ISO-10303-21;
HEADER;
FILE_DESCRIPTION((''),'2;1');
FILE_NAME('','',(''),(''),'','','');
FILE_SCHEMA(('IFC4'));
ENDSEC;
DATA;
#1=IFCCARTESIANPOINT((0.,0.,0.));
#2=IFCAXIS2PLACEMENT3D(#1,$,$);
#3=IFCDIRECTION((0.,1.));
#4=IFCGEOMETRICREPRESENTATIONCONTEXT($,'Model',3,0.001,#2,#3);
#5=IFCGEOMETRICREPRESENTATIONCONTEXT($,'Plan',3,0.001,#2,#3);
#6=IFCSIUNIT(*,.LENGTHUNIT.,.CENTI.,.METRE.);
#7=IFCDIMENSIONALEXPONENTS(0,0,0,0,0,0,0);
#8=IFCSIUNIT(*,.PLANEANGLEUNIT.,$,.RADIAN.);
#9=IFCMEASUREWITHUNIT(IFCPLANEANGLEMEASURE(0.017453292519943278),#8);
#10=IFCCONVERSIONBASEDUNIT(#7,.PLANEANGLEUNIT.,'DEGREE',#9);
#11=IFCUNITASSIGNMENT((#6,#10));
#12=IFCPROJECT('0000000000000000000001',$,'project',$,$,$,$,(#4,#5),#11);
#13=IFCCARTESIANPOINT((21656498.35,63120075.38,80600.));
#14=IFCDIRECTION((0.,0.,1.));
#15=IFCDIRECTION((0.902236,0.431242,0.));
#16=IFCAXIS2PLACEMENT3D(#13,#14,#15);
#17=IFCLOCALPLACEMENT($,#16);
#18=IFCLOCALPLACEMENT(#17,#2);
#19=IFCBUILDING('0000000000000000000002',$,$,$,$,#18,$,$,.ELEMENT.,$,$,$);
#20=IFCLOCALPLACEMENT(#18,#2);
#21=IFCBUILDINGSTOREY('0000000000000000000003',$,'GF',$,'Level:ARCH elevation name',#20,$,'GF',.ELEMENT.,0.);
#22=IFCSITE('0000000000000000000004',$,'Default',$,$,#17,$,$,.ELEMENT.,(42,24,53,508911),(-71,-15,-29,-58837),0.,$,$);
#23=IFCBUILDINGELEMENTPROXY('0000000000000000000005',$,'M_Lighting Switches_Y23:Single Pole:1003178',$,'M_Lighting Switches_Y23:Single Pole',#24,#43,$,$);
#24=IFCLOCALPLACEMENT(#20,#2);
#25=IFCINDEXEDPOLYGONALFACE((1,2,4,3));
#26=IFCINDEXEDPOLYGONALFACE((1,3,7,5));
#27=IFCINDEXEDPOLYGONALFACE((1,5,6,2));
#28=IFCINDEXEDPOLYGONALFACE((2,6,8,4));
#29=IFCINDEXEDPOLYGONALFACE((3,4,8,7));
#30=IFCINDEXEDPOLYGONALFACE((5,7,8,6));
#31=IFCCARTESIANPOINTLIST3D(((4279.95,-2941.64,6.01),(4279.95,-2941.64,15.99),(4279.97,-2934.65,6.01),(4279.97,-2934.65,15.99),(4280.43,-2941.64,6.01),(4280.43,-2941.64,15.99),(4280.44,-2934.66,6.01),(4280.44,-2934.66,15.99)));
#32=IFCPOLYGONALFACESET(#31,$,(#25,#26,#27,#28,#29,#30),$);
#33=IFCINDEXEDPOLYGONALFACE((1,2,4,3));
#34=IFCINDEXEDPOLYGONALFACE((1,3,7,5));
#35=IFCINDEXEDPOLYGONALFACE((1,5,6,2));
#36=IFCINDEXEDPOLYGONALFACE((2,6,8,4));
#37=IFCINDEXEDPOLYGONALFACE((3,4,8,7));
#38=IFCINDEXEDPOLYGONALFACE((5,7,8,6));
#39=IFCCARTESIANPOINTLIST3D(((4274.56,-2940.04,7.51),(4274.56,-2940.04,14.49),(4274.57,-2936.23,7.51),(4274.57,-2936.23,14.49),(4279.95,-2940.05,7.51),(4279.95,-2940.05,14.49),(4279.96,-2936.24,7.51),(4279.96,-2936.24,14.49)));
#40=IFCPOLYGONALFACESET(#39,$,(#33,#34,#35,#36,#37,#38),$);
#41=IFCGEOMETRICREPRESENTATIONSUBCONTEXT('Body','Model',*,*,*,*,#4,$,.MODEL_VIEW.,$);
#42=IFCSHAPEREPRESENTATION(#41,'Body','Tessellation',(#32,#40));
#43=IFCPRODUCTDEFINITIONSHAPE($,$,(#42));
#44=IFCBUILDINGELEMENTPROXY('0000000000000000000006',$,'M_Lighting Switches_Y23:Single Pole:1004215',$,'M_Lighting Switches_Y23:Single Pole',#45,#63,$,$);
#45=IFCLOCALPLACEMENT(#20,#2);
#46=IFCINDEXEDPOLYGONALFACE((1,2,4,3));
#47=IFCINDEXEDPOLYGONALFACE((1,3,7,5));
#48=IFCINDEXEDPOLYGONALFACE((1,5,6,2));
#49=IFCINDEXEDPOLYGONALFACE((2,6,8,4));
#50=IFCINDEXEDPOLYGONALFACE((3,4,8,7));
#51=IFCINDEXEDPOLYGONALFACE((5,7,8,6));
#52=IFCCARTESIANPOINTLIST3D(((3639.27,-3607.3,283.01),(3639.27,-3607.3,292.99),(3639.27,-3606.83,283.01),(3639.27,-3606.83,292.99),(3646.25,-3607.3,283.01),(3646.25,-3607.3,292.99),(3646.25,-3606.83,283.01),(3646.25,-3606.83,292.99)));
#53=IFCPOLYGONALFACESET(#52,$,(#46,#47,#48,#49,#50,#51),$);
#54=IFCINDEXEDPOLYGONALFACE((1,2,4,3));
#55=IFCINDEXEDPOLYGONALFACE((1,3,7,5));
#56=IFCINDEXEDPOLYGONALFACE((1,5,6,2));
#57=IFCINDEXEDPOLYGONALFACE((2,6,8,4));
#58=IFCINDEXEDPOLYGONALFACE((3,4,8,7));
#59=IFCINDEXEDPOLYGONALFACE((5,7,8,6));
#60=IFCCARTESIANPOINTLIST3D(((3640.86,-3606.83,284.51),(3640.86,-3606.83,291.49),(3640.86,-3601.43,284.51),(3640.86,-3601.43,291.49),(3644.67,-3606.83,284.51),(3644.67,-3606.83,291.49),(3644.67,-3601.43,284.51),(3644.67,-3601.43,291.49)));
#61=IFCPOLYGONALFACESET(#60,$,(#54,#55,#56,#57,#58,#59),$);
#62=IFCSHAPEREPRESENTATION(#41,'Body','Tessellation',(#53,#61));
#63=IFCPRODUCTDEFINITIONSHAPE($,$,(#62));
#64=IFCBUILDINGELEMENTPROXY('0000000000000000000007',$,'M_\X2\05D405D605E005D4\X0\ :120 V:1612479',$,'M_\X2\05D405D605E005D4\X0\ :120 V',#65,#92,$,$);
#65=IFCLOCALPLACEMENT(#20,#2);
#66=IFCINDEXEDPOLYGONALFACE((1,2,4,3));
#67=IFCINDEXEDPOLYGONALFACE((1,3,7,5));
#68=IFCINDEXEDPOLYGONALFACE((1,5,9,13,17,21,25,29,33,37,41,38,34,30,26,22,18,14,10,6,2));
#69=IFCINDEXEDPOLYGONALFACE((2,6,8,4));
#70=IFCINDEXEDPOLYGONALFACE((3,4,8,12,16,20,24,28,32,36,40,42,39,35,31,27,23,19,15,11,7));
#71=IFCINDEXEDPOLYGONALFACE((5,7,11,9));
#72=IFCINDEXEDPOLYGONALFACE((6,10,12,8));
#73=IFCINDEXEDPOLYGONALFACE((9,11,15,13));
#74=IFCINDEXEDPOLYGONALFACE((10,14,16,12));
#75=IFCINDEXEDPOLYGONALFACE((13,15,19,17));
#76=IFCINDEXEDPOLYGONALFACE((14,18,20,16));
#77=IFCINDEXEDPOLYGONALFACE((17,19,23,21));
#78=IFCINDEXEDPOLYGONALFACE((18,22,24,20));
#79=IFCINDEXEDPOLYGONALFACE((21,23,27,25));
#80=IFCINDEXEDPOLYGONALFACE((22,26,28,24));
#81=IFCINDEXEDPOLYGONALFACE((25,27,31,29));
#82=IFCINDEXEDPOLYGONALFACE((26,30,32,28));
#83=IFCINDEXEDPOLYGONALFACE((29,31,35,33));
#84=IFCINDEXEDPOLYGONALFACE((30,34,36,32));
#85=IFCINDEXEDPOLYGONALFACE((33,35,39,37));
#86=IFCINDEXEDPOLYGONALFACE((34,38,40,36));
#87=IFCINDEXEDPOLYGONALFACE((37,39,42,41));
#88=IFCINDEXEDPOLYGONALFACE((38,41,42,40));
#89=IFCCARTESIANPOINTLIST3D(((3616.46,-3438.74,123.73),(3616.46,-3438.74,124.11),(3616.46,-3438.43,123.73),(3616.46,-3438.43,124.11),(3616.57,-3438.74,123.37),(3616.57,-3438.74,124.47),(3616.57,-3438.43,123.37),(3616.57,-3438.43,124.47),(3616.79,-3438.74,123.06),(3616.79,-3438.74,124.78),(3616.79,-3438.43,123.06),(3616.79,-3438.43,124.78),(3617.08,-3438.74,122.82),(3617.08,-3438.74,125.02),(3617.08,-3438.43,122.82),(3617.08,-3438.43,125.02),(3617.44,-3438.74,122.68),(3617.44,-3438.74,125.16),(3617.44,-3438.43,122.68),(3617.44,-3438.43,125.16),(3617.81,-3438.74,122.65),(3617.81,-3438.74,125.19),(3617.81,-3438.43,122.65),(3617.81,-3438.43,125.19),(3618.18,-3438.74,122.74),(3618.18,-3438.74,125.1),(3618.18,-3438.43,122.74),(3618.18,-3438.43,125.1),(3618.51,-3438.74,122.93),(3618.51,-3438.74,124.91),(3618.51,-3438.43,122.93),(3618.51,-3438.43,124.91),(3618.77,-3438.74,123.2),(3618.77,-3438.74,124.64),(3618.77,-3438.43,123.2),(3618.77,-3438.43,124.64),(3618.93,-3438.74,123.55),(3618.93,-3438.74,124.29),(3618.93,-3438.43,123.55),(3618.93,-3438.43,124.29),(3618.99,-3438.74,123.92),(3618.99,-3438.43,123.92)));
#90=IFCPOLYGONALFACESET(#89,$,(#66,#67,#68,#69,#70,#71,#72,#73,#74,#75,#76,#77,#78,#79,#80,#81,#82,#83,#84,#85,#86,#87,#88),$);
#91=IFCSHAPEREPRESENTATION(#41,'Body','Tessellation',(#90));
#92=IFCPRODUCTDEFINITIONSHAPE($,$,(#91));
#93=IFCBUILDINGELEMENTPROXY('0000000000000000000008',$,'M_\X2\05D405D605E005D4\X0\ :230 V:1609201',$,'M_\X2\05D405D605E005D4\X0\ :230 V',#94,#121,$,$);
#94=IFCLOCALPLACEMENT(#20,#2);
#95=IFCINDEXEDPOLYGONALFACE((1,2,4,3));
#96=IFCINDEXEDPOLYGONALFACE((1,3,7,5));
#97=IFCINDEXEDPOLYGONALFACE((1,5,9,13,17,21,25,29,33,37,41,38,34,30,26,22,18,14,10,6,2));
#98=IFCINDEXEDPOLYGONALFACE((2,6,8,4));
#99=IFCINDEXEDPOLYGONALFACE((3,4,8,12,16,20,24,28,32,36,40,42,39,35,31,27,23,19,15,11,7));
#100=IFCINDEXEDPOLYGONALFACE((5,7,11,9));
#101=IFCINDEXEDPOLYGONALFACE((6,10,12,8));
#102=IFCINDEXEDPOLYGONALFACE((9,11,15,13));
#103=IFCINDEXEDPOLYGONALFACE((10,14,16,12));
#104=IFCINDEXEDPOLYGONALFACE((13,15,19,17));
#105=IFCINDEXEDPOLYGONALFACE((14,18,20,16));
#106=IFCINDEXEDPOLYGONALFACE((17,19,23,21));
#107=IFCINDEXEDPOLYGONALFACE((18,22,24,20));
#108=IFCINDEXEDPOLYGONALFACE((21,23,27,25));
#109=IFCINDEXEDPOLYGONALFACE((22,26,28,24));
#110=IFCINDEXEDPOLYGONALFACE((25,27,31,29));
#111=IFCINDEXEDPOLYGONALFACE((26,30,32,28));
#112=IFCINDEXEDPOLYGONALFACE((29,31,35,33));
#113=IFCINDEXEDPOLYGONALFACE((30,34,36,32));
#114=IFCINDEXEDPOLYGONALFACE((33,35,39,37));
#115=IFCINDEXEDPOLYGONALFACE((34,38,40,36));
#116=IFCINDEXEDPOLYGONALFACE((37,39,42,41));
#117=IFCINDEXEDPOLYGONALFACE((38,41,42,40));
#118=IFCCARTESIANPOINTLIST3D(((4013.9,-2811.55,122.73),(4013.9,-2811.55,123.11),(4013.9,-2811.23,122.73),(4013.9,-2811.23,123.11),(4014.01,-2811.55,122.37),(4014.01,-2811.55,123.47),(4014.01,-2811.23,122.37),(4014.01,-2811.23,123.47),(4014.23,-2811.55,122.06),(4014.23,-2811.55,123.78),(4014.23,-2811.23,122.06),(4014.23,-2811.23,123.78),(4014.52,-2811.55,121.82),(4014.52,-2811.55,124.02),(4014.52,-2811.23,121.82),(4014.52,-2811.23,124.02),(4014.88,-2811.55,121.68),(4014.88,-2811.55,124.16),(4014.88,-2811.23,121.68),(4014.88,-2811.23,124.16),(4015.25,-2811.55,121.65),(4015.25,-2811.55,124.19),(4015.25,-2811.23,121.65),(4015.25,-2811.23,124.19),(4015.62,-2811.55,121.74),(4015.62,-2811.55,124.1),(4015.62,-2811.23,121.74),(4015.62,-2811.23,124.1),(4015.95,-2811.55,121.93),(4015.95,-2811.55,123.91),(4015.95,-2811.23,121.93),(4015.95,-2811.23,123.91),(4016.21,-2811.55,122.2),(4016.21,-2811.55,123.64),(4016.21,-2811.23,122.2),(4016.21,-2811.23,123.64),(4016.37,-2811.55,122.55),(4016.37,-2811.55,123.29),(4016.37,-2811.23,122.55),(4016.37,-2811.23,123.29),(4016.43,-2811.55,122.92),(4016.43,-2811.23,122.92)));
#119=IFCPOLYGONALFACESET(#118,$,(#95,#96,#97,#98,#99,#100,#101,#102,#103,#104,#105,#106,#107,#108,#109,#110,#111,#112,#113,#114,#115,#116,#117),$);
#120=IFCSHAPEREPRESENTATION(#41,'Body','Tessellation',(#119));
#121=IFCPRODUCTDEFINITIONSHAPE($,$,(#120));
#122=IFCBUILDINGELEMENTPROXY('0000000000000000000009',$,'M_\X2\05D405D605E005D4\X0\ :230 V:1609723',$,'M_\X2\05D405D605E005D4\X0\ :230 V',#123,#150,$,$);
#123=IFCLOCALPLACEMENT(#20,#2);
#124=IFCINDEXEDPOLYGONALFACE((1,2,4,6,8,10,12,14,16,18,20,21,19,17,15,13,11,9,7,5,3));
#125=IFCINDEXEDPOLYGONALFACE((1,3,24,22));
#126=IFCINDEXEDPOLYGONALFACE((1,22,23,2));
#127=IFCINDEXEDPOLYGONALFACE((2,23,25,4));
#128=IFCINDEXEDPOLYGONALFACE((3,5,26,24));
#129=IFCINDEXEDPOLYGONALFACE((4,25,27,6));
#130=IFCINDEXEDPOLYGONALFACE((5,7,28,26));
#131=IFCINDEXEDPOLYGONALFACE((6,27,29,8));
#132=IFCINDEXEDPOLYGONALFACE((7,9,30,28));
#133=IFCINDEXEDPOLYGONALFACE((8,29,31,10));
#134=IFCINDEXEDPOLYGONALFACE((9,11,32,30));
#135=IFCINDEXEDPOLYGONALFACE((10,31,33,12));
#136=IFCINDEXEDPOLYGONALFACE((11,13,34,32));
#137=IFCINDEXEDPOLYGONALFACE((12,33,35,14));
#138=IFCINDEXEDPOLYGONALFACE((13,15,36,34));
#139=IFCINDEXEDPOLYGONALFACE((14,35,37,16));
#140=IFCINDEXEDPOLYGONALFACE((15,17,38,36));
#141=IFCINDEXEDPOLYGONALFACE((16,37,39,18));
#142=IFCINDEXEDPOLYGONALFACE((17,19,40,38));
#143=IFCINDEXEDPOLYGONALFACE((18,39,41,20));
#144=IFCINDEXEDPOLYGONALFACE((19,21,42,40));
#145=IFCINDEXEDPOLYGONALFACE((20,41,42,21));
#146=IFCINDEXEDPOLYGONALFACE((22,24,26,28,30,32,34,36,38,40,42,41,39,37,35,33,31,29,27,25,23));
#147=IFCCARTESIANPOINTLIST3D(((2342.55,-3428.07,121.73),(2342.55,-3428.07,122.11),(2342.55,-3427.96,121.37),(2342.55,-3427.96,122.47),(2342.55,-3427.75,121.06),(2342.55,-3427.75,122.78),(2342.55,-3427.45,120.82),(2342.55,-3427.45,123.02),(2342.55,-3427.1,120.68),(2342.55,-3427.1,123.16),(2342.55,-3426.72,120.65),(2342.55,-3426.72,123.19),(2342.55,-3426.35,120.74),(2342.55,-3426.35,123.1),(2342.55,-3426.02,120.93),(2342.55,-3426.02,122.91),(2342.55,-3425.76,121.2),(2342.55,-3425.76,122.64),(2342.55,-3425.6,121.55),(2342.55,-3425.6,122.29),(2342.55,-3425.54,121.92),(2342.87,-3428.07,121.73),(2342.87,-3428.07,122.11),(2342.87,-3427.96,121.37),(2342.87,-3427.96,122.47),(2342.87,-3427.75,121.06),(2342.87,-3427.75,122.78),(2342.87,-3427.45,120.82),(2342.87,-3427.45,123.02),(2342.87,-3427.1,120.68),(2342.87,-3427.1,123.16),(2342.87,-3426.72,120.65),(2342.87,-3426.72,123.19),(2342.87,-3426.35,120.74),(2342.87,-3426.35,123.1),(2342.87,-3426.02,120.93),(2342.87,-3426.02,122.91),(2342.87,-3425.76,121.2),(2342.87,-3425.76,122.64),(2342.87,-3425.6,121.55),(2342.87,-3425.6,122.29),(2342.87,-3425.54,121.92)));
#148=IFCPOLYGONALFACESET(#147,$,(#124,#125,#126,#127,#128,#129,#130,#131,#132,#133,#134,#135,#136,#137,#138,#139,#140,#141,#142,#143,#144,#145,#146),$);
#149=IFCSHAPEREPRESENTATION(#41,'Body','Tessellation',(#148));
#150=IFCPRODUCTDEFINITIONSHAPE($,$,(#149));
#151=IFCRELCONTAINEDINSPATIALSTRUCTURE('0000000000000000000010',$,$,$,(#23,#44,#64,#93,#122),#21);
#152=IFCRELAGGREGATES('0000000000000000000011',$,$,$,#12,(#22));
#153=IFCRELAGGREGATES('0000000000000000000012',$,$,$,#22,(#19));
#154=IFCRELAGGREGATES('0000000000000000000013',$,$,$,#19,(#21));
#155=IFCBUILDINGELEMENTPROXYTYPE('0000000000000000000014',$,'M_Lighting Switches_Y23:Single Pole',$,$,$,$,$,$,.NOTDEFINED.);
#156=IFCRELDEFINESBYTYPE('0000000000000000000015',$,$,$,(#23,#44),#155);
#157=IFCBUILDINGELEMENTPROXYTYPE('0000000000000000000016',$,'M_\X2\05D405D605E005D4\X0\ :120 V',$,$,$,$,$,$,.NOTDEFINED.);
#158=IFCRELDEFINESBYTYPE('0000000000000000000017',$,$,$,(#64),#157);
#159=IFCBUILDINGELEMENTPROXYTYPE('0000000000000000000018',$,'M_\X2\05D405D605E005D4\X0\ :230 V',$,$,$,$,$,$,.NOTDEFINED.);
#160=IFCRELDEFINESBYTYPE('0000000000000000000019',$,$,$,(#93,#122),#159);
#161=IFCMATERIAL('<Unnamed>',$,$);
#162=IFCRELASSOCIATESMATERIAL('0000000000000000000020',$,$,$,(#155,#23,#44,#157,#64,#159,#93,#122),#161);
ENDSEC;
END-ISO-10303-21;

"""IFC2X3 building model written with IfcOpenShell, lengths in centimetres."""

from ifc_helpers import new_model, entity, si_unit, converted_unit, direction, frame, frame_2d, origin, place, context, subcontext, project, spatial, rectangle, circle, extrude, source, transform, mapped, material, type_object, type_shapes, element, save


model = new_model("IFC2X3")

# Units and contexts
model_context = context("Model", 3, precision=0.001, world=origin(), true_north=direction((0.0, 1.0)))
plan_context = context("Plan", 3, precision=0.001, world=origin(), true_north=direction((0.0, 1.0)))
body_context = subcontext(model_context, "Body", "Model", "MODEL_VIEW")
ifc_project = project(units=[si_unit("LENGTHUNIT", "METRE", prefix="CENTI"), converted_unit("PLANEANGLEUNIT", "DEGREE", entity("IfcPlaneAngleMeasure", 0.017453292519943278), si_unit("PLANEANGLEUNIT", "RADIAN"), dimensions=[0, 0, 0, 0, 0, 0, 0])], contexts=[model_context, plan_context])

# Site, building, storey
site_placement = place(None, frame((21656498.35, 63120075.38, 80600.0), z_axis=(0.0, 0.0, 1.0), x_axis=(0.902236, 0.431242, 0.0)))
site = spatial("IfcSite", under=ifc_project, at=site_placement, Name="Default", CompositionType="ELEMENT", RefLatitude=(42, 24, 53, 508911), RefLongitude=(-71, -15, -29, -58837), RefElevation=0.0)
building_placement = place(site_placement, origin())
building = spatial("IfcBuilding", under=site, at=building_placement, CompositionType="ELEMENT")
storey_placement = place(building_placement, origin())
storey = spatial("IfcBuildingStorey", under=building, at=storey_placement, Name="GF", ObjectType="Level:ARCH elevation name", LongName="GF", CompositionType="ELEMENT", Elevation=0.0)

# Building element proxies
ifc_material_1 = material(Name="<Unnamed>")
building_element_proxy_type_1 = type_object("IfcBuildingElementProxyType", Name="M_Lighting Switches_Y23:Single Pole", PredefinedType="NOTDEFINED", material=ifc_material_1)
shared_shape_1 = source(origin(), body_context, "Body", "SweptSolid", [
    extrude(rectangle(XDim=6.99, YDim=9.98, at=frame_2d((0.0, 0.0), x_axis=(1.0, 0.0))), frame((0.0, 0.0, 0.0), z_axis=(0.0, 0.0, 1.0), x_axis=(-1.0, 0.0, 0.0)), (0.0, 0.0, 1.0), 0.48),
    extrude(rectangle(XDim=3.81, YDim=6.98, at=frame_2d((0.0, 0.0), x_axis=(1.0, 0.0))), frame((0.0, 0.0, -5.4), z_axis=(0.0, 0.0, 1.0), x_axis=(-1.0, 0.0, 0.0)), (0.0, 0.0, 1.0), 5.4),
])
type_shapes(building_element_proxy_type_1, [shared_shape_1])
for number, where, z_axis, x_axis, name in (
    (1, (4279.96, -2938.15, 11.0), (0.999997, -0.002623, 0.0), (0.002623, 0.999997, 0.0), "M_Lighting Switches_Y23:Single Pole:1003178"),
    (2, (3642.76, -3606.83, 288.0), (0.0, -1.0, 0.0), (1.0, 0.0, 0.0), "M_Lighting Switches_Y23:Single Pole:1004215"),
):
    element("IfcBuildingElementProxy", number, at=place(storey_placement, frame(where, z_axis=z_axis, x_axis=x_axis)), inside=storey, type_object=building_element_proxy_type_1, material=ifc_material_1, Name=name, ObjectType="M_Lighting Switches_Y23:Single Pole", context=body_context, shape_type="MappedRepresentation", body=[
        mapped(shared_shape_1, transform((0.0, 0.0, 0.0), scale=1.0)),
    ])
building_element_proxy_type_2 = type_object("IfcBuildingElementProxyType", Name="M_הזנה :120 V", PredefinedType="NOTDEFINED", material=ifc_material_1)
shared_shape_2 = source(origin(), body_context, "Body", "SweptSolid", [
    extrude(circle(Radius=1.27, at=frame_2d((0.0, 0.0), x_axis=(1.0, 0.0))), origin(), (0.0, 0.0, 1.0), 0.32),
])
type_shapes(building_element_proxy_type_2, [shared_shape_2])
proxy_1_placement = place(storey_placement, frame((3617.72, -3438.43, 123.92), z_axis=(0.0, -1.0, 0.0), x_axis=(1.0, 0.0, 0.0)))
element("IfcBuildingElementProxy", 3, at=proxy_1_placement, inside=storey, type_object=building_element_proxy_type_2, material=ifc_material_1, Name="M_הזנה :120 V:1612479", ObjectType="M_הזנה :120 V", context=body_context, shape_type="MappedRepresentation", body=[
    mapped(shared_shape_2, transform((0.0, 0.0, 0.0), scale=1.0)),
])
building_element_proxy_type_3 = type_object("IfcBuildingElementProxyType", Name="M_הזנה :230 V", PredefinedType="NOTDEFINED", material=ifc_material_1)
shared_shape_3 = source(origin(), body_context, "Body", "SweptSolid", [
    extrude(circle(Radius=1.27, at=frame_2d((0.0, 0.0), x_axis=(1.0, 0.0))), origin(), (0.0, 0.0, 1.0), 0.32),
])
type_shapes(building_element_proxy_type_3, [shared_shape_3])
for number, where, z_axis, x_axis, name in (
    (4, (4015.16, -2811.23, 122.92), (0.0, -1.0, 0.0), (1.0, 0.0, 0.0), "M_הזנה :230 V:1609201"),
    (5, (2342.55, -3426.81, 121.92), (1.0, 0.0, 0.0), (0.0, 1.0, 0.0), "M_הזנה :230 V:1609723"),
):
    element("IfcBuildingElementProxy", number, at=place(storey_placement, frame(where, z_axis=z_axis, x_axis=x_axis)), inside=storey, type_object=building_element_proxy_type_3, material=ifc_material_1, Name=name, ObjectType="M_הזנה :230 V", context=body_context, shape_type="MappedRepresentation", body=[
        mapped(shared_shape_3, transform((0.0, 0.0, 0.0), scale=1.0)),
    ])

save(model, "model.ifc")
